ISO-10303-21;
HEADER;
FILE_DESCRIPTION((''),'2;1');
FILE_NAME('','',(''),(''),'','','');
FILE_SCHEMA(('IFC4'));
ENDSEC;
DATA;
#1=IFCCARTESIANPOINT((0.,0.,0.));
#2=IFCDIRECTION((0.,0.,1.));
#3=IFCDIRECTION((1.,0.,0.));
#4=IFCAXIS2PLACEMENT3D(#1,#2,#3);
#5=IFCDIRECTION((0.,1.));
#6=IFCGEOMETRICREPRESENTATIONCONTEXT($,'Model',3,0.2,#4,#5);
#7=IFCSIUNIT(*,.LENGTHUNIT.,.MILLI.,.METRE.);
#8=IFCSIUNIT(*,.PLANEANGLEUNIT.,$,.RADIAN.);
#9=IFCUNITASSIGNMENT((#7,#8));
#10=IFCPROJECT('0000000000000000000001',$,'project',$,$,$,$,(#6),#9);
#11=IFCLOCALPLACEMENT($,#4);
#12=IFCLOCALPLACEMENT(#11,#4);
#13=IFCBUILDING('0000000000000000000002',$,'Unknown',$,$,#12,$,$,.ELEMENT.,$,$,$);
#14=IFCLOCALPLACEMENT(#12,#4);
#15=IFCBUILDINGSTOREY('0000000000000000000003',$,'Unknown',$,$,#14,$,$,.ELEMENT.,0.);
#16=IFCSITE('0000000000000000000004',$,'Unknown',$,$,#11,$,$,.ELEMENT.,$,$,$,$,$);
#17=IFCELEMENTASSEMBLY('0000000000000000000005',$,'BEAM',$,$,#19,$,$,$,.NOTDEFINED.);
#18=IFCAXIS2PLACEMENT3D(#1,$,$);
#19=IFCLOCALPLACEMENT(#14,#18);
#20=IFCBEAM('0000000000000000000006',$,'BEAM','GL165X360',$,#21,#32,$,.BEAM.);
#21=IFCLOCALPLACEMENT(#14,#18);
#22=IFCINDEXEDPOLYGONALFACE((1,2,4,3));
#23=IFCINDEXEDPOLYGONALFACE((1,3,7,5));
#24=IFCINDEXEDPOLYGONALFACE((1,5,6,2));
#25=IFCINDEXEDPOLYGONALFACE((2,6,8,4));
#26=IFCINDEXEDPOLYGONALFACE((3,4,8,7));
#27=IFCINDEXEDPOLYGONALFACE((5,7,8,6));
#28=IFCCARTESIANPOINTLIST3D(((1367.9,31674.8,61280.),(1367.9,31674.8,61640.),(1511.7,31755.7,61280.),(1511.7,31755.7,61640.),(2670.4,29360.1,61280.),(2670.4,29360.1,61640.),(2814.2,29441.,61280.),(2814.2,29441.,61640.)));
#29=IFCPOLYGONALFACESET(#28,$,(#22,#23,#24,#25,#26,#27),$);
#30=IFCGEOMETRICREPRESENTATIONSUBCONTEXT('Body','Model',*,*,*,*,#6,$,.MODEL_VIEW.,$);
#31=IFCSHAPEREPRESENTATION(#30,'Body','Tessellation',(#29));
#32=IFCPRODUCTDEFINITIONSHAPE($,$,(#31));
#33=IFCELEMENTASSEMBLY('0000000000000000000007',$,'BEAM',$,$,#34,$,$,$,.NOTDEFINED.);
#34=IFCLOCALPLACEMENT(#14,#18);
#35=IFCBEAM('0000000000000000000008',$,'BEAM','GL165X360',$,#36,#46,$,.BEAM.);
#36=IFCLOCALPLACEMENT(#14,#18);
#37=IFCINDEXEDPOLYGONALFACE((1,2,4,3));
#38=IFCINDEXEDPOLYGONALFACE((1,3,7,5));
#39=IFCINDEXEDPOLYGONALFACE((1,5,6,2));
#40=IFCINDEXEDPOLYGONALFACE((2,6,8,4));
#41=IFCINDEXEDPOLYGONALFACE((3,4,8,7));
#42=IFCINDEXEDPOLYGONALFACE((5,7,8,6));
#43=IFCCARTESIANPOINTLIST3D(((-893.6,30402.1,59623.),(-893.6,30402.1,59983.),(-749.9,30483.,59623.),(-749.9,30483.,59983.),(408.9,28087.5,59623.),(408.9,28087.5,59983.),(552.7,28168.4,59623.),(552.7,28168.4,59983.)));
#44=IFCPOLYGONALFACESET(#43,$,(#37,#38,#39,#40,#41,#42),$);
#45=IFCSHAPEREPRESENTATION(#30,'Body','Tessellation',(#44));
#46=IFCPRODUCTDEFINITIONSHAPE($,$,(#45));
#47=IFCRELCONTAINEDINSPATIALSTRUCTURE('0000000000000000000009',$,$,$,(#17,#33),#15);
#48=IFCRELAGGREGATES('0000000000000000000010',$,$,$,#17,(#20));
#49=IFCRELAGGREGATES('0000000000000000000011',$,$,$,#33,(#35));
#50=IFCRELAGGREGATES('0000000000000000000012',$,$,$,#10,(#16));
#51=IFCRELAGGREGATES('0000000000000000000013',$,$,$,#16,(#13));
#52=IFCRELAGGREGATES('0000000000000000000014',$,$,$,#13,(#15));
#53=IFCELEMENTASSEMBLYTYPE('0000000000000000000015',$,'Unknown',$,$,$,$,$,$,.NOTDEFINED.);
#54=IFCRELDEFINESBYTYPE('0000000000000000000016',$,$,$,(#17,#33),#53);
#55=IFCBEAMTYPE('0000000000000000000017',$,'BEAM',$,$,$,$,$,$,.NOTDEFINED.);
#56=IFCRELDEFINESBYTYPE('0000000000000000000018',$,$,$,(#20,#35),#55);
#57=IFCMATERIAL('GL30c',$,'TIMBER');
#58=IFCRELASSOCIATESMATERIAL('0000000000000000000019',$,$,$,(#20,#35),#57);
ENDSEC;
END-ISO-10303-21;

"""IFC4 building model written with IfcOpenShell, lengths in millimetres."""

from ifc_helpers import new_model, si_unit, direction, frame, origin_with_axes, place, context, subcontext, project, spatial, polyline, outline, extrude, material, material_profile, profile_set, profile_usage, type_object, element, aggregate, save


model = new_model("IFC4")

# Units and contexts
model_context = context("Model", 3, precision=0.2, world=origin_with_axes(), true_north=direction((0.0, 1.0)))
body_context = subcontext(model_context, "Body", "Model", "MODEL_VIEW")
ifc_project = project(units=[si_unit("LENGTHUNIT", "METRE", prefix="MILLI"), si_unit("PLANEANGLEUNIT", "RADIAN")], contexts=[model_context])

# Site, building, storey
site_placement = place(None, origin_with_axes())
site = spatial("IfcSite", under=ifc_project, at=site_placement, Name="Unknown", CompositionType="ELEMENT")
building_placement = place(site_placement, origin_with_axes())
building = spatial("IfcBuilding", under=site, at=building_placement, Name="Unknown", CompositionType="ELEMENT")
storey_placement = place(building_placement, origin_with_axes())
storey = spatial("IfcBuildingStorey", under=building, at=storey_placement, Name="Unknown", CompositionType="ELEMENT", Elevation=0.0)

# Shared definitions
element_assembly_type = type_object("IfcElementAssemblyType", Name="Unknown", PredefinedType="NOTDEFINED")
ifc_material_1 = material(Name="GL30c", Category="TIMBER")

# Element assemblies, beams
assembly_1_placement = place(storey_placement, frame((1439.8, 31715.2, 61460.0), z_axis=(-0.871487, -0.490418, 0.0), x_axis=(0.490421, -0.871485, 0.0)))
assembly_1 = element("IfcElementAssembly", 1, at=assembly_1_placement, inside=storey, type_object=element_assembly_type, Name="BEAM", PredefinedType="NOTDEFINED")
ifc_material_profile_1 = material_profile(ifc_material_1, outline(polyline([(-82.5, 180.0), (-82.5, -180.0), (82.5, -180.0), (82.5, 180.0), (-82.5, 180.0)])), Name="GL165X360")
ifc_profile_set_1 = profile_set([ifc_material_profile_1])
ifc_profile_usage_1 = profile_usage(ifc_profile_set_1, cardinal=9)
beam_type_1 = type_object("IfcBeamType", Name="BEAM")
beam_1_placement = place(assembly_1_placement, origin_with_axes())
beam_1 = element("IfcBeam", 2, at=beam_1_placement, type_object=beam_type_1, material=ifc_profile_usage_1, Name="BEAM", Description="GL165X360", PredefinedType="BEAM", context=body_context, shape_type="SolidModel", body=[
    extrude(outline(polyline([(-82.5, 180.0), (-82.5, -180.0), (82.5, -180.0), (82.5, 180.0), (-82.5, 180.0)])), frame((0.0, 0.0, 0.0), z_axis=(-1.0, 0.0, 0.0), x_axis=(0.0, 0.0, 1.0)), (0.0, 0.0, -1.0), 2656.0),
])
aggregate(assembly_1, [beam_1])
assembly_2_placement = place(storey_placement, frame((480.8, 28127.9, 59803.0), z_axis=(0.871484, 0.490423, 0.0), x_axis=(-0.490421, 0.871486, 0.0)))
assembly_2 = element("IfcElementAssembly", 3, at=assembly_2_placement, inside=storey, type_object=element_assembly_type, Name="BEAM", PredefinedType="NOTDEFINED")
beam_2_placement = place(assembly_2_placement, origin_with_axes())
beam_2 = element("IfcBeam", 4, at=beam_2_placement, type_object=beam_type_1, material=ifc_profile_usage_1, Name="BEAM", Description="GL165X360", PredefinedType="BEAM", context=body_context, shape_type="SolidModel", body=[
    extrude(outline(polyline([(-82.5, 180.0), (-82.5, -180.0), (82.5, -180.0), (82.5, 180.0), (-82.5, 180.0)])), frame((0.0, 0.0, 0.0), z_axis=(-1.0, 0.0, 0.0), x_axis=(0.0, 0.0, 1.0)), (0.0, 0.0, -1.0), 2656.0),
])
aggregate(assembly_2, [beam_2])

save(model, "model.ifc")
